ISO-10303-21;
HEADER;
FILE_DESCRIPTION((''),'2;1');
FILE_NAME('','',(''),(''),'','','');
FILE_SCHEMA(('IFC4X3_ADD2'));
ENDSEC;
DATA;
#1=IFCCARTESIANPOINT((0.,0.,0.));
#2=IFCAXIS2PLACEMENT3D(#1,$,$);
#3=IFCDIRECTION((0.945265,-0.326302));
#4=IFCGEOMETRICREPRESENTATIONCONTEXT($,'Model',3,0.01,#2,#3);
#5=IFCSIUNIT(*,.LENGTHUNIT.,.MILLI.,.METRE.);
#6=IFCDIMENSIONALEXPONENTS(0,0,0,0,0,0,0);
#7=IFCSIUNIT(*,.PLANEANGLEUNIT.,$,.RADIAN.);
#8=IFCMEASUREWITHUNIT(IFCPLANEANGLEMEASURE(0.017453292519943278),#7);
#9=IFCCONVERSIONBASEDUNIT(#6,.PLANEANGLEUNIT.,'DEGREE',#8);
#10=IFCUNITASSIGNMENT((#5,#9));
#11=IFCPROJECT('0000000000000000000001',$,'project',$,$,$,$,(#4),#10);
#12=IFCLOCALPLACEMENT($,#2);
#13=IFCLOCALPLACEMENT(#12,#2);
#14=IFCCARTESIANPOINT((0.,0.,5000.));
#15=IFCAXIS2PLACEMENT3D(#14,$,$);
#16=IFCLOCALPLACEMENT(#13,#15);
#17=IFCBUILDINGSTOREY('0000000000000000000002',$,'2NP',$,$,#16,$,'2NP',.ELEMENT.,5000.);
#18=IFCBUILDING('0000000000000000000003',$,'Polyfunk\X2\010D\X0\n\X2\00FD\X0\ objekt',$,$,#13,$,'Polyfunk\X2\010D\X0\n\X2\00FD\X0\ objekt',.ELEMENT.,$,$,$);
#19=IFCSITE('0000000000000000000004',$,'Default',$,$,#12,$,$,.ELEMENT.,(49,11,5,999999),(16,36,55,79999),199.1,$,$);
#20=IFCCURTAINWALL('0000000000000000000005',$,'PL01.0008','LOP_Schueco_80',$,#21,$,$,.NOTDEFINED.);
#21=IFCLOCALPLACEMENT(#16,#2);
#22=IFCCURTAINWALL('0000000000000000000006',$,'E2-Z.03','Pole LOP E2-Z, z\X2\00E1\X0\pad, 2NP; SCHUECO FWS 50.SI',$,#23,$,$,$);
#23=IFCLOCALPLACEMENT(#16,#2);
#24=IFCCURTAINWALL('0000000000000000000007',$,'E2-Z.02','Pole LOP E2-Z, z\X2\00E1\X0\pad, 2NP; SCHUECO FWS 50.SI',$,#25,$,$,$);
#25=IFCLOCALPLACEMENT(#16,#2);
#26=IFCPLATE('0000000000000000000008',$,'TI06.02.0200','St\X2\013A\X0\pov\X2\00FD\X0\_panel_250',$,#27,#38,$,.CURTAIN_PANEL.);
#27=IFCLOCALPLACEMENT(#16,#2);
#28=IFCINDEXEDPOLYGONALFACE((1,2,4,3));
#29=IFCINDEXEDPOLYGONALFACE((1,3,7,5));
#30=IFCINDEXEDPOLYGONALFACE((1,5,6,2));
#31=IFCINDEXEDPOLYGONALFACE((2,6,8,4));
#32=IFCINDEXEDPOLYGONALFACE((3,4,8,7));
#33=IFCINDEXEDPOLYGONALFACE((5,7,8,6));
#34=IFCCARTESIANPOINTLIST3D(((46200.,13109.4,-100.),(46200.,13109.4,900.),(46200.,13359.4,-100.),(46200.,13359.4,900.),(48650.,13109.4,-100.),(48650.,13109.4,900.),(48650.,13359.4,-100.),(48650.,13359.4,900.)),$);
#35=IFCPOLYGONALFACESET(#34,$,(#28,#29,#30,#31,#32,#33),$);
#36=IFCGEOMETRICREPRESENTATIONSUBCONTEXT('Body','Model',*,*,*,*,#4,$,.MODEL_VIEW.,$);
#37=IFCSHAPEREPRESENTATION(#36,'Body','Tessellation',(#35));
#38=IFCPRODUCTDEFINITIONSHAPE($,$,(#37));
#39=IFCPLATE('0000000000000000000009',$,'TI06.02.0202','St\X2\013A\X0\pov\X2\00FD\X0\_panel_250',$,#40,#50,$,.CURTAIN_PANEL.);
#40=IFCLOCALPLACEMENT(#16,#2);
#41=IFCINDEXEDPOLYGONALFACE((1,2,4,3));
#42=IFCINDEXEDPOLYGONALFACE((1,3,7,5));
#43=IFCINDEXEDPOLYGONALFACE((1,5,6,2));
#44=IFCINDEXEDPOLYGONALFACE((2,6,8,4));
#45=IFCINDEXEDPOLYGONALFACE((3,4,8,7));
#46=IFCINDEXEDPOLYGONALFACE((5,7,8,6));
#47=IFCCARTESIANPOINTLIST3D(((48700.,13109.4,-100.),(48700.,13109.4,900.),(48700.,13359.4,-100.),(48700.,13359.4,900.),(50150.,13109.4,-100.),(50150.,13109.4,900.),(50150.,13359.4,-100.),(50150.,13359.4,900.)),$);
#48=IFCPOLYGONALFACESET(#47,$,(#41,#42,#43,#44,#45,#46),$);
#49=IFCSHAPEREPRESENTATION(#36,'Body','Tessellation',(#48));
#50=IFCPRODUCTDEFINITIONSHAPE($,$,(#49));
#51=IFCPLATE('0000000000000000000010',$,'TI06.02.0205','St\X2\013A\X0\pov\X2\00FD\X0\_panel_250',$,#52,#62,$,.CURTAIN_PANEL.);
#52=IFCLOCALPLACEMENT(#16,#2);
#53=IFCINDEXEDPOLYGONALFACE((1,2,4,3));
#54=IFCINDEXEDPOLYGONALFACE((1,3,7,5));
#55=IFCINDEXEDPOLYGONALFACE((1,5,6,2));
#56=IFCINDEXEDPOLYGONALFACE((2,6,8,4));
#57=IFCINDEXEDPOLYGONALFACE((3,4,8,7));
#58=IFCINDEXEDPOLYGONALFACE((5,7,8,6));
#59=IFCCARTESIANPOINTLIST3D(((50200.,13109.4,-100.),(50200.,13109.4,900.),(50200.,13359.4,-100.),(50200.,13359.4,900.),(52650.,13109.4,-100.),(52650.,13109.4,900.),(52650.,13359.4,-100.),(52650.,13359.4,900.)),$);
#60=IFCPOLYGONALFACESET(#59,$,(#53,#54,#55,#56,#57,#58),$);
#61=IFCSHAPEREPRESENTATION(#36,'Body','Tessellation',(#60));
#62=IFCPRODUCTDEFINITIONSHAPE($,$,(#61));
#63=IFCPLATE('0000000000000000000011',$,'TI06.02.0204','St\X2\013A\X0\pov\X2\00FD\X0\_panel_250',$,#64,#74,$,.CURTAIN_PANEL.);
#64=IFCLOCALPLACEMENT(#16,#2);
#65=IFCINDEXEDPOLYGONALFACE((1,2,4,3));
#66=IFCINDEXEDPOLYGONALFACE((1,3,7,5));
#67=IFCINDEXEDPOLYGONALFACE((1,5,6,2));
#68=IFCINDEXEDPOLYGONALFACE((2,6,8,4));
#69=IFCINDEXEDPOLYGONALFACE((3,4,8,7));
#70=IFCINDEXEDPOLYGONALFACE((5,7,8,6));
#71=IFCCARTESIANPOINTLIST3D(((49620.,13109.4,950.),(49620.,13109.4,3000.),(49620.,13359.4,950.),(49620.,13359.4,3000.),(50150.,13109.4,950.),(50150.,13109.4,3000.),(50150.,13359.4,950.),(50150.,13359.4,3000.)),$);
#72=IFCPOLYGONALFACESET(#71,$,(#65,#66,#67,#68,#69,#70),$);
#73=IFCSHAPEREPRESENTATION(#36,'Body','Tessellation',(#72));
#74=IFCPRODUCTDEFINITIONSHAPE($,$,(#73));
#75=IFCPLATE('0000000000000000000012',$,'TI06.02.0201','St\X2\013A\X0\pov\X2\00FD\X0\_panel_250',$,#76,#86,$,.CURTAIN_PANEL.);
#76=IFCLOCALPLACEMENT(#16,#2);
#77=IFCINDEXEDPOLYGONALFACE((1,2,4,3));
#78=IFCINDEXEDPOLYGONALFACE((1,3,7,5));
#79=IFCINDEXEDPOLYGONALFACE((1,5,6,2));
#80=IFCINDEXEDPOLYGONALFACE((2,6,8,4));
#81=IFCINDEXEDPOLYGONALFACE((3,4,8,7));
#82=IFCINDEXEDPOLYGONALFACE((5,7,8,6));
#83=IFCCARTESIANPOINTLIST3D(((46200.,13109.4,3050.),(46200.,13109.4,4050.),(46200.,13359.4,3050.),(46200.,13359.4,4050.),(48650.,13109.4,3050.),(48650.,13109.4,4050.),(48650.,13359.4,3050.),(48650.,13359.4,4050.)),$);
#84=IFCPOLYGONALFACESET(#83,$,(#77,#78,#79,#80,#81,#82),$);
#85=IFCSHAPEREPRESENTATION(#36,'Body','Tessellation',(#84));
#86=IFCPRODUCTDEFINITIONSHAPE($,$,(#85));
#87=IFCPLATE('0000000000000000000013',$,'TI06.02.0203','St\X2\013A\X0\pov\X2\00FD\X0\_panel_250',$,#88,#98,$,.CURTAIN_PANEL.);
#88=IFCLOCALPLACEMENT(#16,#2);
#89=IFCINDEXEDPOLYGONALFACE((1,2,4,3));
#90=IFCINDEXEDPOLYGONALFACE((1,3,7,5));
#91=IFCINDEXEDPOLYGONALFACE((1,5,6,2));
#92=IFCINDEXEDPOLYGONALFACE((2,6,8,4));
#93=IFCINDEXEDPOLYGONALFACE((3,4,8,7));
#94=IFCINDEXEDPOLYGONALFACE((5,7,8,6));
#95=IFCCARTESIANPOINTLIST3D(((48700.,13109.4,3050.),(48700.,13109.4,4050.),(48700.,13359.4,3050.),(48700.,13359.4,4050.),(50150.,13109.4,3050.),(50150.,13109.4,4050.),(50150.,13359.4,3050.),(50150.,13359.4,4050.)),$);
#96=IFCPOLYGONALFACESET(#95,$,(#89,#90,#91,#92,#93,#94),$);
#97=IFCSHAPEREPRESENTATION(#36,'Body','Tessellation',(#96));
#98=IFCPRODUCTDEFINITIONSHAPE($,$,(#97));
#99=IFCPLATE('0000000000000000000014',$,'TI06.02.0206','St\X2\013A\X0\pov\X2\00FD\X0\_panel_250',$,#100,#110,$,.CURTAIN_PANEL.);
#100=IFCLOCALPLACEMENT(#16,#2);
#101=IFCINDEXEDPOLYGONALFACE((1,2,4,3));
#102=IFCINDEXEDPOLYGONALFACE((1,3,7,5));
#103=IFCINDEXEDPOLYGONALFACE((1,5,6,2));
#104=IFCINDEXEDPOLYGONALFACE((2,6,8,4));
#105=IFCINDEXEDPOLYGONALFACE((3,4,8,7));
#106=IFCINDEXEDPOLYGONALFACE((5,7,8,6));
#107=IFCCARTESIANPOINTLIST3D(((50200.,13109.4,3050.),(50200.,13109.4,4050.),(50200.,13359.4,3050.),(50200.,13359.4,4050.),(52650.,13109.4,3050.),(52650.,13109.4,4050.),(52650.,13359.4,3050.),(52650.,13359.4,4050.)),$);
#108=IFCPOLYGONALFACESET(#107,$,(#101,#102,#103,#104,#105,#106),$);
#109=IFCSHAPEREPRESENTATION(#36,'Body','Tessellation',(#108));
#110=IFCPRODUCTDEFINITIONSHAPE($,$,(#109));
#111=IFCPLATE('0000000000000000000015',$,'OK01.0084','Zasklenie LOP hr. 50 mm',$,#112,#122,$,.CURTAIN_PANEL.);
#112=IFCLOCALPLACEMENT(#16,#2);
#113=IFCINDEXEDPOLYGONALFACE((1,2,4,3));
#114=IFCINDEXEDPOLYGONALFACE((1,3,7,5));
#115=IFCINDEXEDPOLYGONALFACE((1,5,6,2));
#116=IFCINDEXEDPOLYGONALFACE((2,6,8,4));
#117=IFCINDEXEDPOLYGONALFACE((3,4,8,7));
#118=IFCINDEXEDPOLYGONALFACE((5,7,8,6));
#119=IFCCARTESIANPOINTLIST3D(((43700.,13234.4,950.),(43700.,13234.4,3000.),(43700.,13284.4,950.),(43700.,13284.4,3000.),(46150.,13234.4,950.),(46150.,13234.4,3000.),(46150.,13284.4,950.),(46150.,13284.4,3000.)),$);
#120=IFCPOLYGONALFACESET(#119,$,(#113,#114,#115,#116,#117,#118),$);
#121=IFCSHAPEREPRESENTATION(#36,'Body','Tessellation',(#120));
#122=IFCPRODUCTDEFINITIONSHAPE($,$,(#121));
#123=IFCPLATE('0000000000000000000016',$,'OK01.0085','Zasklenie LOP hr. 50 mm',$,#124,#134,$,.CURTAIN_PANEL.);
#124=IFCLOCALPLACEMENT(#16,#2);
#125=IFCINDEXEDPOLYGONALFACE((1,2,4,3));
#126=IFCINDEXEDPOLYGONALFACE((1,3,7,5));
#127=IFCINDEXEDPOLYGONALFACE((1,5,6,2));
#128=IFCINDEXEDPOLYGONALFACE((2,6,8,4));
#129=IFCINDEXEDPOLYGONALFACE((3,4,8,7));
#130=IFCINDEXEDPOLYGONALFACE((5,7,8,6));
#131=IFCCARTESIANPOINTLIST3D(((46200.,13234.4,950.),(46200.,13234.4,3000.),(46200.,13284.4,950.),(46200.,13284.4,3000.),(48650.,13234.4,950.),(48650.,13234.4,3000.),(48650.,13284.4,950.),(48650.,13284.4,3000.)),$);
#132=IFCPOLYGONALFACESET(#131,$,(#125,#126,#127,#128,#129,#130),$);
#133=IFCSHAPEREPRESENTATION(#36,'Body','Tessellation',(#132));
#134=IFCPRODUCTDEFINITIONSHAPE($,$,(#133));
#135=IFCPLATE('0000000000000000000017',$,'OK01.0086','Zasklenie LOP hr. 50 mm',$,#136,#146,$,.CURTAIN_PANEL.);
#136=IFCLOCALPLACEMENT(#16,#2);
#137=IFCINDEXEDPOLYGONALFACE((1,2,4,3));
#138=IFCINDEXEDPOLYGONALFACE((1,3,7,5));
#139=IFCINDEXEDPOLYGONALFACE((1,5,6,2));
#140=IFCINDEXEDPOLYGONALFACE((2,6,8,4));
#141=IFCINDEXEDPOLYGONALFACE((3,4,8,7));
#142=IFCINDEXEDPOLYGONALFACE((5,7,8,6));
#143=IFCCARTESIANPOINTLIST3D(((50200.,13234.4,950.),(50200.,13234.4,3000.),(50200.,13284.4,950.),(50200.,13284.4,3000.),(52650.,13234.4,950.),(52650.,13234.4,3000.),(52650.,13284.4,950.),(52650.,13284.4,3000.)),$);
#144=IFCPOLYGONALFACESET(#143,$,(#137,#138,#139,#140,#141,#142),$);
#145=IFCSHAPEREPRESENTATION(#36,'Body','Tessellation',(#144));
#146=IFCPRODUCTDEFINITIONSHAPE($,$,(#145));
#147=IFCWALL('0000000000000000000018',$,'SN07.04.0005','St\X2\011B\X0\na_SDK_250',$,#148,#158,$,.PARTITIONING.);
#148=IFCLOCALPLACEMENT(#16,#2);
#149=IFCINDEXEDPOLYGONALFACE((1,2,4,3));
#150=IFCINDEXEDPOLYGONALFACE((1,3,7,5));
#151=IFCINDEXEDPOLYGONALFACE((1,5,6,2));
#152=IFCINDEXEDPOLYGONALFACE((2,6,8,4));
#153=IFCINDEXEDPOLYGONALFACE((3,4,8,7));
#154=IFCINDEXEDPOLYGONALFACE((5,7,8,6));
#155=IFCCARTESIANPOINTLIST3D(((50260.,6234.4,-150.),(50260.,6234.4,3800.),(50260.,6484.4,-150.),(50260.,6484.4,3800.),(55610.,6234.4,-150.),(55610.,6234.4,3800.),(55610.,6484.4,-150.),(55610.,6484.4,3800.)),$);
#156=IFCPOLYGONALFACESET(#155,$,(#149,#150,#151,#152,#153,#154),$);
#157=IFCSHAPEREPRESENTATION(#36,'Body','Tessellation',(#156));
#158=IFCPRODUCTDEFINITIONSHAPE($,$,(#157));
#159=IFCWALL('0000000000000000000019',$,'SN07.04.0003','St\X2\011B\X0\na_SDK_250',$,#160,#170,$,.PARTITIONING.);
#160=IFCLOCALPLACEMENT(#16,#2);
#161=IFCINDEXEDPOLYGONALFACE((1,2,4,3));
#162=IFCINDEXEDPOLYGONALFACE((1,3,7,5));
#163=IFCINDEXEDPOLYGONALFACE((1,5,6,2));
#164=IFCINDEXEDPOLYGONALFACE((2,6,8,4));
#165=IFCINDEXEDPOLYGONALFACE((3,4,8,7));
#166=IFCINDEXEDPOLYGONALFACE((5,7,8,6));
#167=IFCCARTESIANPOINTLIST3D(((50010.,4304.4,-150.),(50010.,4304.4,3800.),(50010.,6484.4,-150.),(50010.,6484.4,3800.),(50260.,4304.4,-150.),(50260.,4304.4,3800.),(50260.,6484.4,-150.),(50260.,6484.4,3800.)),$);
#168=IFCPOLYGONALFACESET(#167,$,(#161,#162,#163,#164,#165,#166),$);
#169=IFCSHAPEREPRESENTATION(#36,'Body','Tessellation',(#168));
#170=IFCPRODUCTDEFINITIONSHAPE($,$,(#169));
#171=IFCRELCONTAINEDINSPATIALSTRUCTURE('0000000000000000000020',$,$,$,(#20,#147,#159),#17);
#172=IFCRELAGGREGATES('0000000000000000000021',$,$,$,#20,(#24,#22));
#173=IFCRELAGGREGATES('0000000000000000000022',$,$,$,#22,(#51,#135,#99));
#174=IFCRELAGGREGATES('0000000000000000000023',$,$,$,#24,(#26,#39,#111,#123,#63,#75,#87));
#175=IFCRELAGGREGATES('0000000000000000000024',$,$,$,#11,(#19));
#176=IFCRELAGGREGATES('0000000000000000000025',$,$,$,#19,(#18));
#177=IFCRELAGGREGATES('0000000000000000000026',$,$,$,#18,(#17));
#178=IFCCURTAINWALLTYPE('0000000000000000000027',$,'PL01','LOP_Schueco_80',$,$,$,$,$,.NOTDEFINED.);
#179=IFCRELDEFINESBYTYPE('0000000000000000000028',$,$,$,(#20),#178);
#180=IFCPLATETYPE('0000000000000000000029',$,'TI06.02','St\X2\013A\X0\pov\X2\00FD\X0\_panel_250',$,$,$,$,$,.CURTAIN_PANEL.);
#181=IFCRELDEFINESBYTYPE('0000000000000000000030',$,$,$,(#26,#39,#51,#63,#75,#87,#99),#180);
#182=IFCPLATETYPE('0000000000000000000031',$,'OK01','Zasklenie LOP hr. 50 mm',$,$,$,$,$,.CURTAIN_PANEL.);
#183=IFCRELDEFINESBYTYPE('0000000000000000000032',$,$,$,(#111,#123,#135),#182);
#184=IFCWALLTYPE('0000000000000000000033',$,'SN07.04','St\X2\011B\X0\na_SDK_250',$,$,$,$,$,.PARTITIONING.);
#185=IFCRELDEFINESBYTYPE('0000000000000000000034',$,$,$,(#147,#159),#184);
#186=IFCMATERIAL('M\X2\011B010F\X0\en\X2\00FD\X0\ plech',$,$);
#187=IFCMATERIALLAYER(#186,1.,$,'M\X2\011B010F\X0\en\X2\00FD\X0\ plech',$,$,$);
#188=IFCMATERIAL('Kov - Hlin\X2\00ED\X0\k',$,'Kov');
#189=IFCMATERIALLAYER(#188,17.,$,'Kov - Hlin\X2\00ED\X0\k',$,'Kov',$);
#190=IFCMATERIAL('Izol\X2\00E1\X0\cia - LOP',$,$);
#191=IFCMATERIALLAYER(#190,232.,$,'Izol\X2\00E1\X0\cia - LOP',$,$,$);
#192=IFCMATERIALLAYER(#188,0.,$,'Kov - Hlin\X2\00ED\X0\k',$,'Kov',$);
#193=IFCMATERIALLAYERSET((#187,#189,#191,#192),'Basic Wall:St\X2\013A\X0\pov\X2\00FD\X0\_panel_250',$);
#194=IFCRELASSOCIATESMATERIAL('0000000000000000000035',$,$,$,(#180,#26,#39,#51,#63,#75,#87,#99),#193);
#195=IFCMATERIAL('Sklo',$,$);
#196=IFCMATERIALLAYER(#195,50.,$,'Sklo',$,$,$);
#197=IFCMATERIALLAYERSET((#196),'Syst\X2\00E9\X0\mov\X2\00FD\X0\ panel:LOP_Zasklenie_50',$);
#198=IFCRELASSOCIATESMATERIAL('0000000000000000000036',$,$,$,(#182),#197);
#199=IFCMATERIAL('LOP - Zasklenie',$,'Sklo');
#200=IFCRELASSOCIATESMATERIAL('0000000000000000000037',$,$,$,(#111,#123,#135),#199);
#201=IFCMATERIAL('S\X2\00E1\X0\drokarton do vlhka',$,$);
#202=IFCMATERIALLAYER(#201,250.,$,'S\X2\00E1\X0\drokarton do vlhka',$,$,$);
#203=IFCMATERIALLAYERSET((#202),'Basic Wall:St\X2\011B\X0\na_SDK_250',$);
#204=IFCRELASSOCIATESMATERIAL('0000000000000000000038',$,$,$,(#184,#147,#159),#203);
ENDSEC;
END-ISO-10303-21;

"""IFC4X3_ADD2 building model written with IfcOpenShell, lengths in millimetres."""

from ifc_helpers import new_model, entity, si_unit, converted_unit, direction, frame, frame_2d, origin, origin_2d_with_axis, place, context, subcontext, project, spatial, polyline, rectangle, extrude, clip, bounded_halfspace, source, transform, mapped, material, layer, layer_set, layer_usage, type_object, type_shapes, element, aggregate, save


model = new_model("IFC4X3_ADD2")

# Units and contexts
model_context = context("Model", 3, precision=0.01, world=origin(), true_north=direction((0.945265, -0.326302)))
body_context = subcontext(model_context, "Body", "Model", "MODEL_VIEW")
ifc_project = project(units=[si_unit("LENGTHUNIT", "METRE", prefix="MILLI"), converted_unit("PLANEANGLEUNIT", "DEGREE", entity("IfcPlaneAngleMeasure", 0.017453292519943278), si_unit("PLANEANGLEUNIT", "RADIAN"), dimensions=[0, 0, 0, 0, 0, 0, 0])], contexts=[model_context])

# Site, building, storey
site_placement = place(None, origin())
site = spatial("IfcSite", under=ifc_project, at=site_placement, Name="Default", CompositionType="ELEMENT", RefLatitude=(49, 11, 5, 999999), RefLongitude=(16, 36, 55, 79999), RefElevation=199.1)
building_placement = place(site_placement, origin())
building = spatial("IfcBuilding", under=site, at=building_placement, Name="Polyfunkčný objekt", LongName="Polyfunkčný objekt", CompositionType="ELEMENT")
storey_placement = place(building_placement, frame((0.0, 0.0, 5000.0)))
storey = spatial("IfcBuildingStorey", under=building, at=storey_placement, Name="2NP", LongName="2NP", CompositionType="ELEMENT", Elevation=5000.0)

# Curtain walls, plates
curtain_wall_type = type_object("IfcCurtainWallType", Name="PL01", Description="LOP_Schueco_80", PredefinedType="NOTDEFINED")
curtain_wall_1_placement = place(storey_placement, frame((0.0, 0.0, -5000.0)))
curtain_wall_1 = element("IfcCurtainWall", 1, at=curtain_wall_1_placement, inside=storey, type_object=curtain_wall_type, Name="PL01.0008", Description="LOP_Schueco_80", PredefinedType="NOTDEFINED")
curtain_wall_2 = element("IfcCurtainWall", 2, Name="E2-Z.03", Description="Pole LOP E2-Z, západ, 2NP; SCHUECO FWS 50.SI")
curtain_wall_3 = element("IfcCurtainWall", 3, Name="E2-Z.02", Description="Pole LOP E2-Z, západ, 2NP; SCHUECO FWS 50.SI")
aggregate(curtain_wall_1, [curtain_wall_3, curtain_wall_2])
ifc_material_1 = material(Name="Měďený plech")
ifc_layer_1 = layer(ifc_material_1, 1.0, Name="Měďený plech")
ifc_material_2 = material(Name="Kov - Hliník", Category="Kov")
ifc_layer_2 = layer(ifc_material_2, 17.0, Name="Kov - Hliník", Category="Kov")
ifc_material_3 = material(Name="Izolácia - LOP")
ifc_layer_3 = layer(ifc_material_3, 232.0, Name="Izolácia - LOP")
ifc_layer_4 = layer(ifc_material_2, 0.0, Name="Kov - Hliník", Category="Kov")
ifc_layer_set_1 = layer_set([ifc_layer_1, ifc_layer_2, ifc_layer_3, ifc_layer_4], Name="Basic Wall:Stĺpový_panel_250")
ifc_layer_usage_1 = layer_usage(ifc_layer_set_1, "AXIS2", "NEGATIVE", 125.0)
plate_type_1 = type_object("IfcPlateType", Name="TI06.02", Description="Stĺpový_panel_250", PredefinedType="CURTAIN_PANEL", material=ifc_layer_set_1)
plate_1_placement = place(storey_placement, frame((46200.0, 13234.4, -100.0)))
plate_1 = element("IfcPlate", 4, at=plate_1_placement, type_object=plate_type_1, material=ifc_layer_usage_1, Name="TI06.02.0200", Description="Stĺpový_panel_250", PredefinedType="CURTAIN_PANEL", context=body_context, shape_type="SweptSolid", body=[
    extrude(rectangle(XDim=250.0, YDim=2450.0, at=frame_2d((0.0, 0.0), x_axis=(1.0, 0.0))), frame((1225.0, 0.0, 0.0), z_axis=(0.0, 0.0, 1.0), x_axis=(0.0, 1.0, 0.0)), (0.0, 0.0, 1.0), 1000.0),
])
ifc_layer_usage_2 = layer_usage(ifc_layer_set_1, "AXIS2", "NEGATIVE", 125.0)
plate_2_placement = place(storey_placement, frame((48700.0, 13234.4, -100.0)))
plate_2 = element("IfcPlate", 5, at=plate_2_placement, type_object=plate_type_1, material=ifc_layer_usage_2, Name="TI06.02.0202", Description="Stĺpový_panel_250", PredefinedType="CURTAIN_PANEL", context=body_context, shape_type="SweptSolid", body=[
    extrude(rectangle(XDim=250.0, YDim=1450.0, at=frame_2d((0.0, 0.0), x_axis=(1.0, 0.0))), frame((725.0, 0.0, 0.0), z_axis=(0.0, 0.0, 1.0), x_axis=(0.0, 1.0, 0.0)), (0.0, 0.0, 1.0), 1000.0),
])
ifc_layer_usage_3 = layer_usage(ifc_layer_set_1, "AXIS2", "NEGATIVE", 125.0)
plate_3_placement = place(storey_placement, frame((50200.0, 13234.4, -100.0)))
plate_3 = element("IfcPlate", 6, at=plate_3_placement, type_object=plate_type_1, material=ifc_layer_usage_3, Name="TI06.02.0205", Description="Stĺpový_panel_250", PredefinedType="CURTAIN_PANEL", context=body_context, shape_type="SweptSolid", body=[
    extrude(rectangle(XDim=250.0, YDim=2450.0, at=origin_2d_with_axis()), frame((1225.0, 0.0, 0.0), z_axis=(0.0, 0.0, 1.0), x_axis=(0.0, 1.0, 0.0)), (0.0, 0.0, 1.0), 1000.0),
])
ifc_layer_usage_4 = layer_usage(ifc_layer_set_1, "AXIS2", "NEGATIVE", 125.0)
plate_4_placement = place(storey_placement, frame((49620.0, 13234.4, 950.0)))
plate_4 = element("IfcPlate", 7, at=plate_4_placement, type_object=plate_type_1, material=ifc_layer_usage_4, Name="TI06.02.0204", Description="Stĺpový_panel_250", PredefinedType="CURTAIN_PANEL", context=body_context, shape_type="SweptSolid", body=[
    extrude(rectangle(XDim=250.0, YDim=530.0, at=frame_2d((0.0, 0.0), x_axis=(1.0, 0.0))), frame((265.0, 0.0, 0.0), z_axis=(0.0, 0.0, 1.0), x_axis=(0.0, 1.0, 0.0)), (0.0, 0.0, 1.0), 2050.0),
])
ifc_layer_usage_5 = layer_usage(ifc_layer_set_1, "AXIS2", "NEGATIVE", 125.0)
plate_5_placement = place(storey_placement, frame((46200.0, 13234.4, 3050.0)))
plate_5 = element("IfcPlate", 8, at=plate_5_placement, type_object=plate_type_1, material=ifc_layer_usage_5, Name="TI06.02.0201", Description="Stĺpový_panel_250", PredefinedType="CURTAIN_PANEL", context=body_context, shape_type="SweptSolid", body=[
    extrude(rectangle(XDim=250.0, YDim=2450.0, at=frame_2d((0.0, 0.0), x_axis=(1.0, 0.0))), frame((1225.0, 0.0, 0.0), z_axis=(0.0, 0.0, 1.0), x_axis=(0.0, 1.0, 0.0)), (0.0, 0.0, 1.0), 1000.0),
])
ifc_layer_usage_6 = layer_usage(ifc_layer_set_1, "AXIS2", "NEGATIVE", 125.0)
plate_6_placement = place(storey_placement, frame((48700.0, 13234.4, 3050.0)))
plate_6 = element("IfcPlate", 9, at=plate_6_placement, type_object=plate_type_1, material=ifc_layer_usage_6, Name="TI06.02.0203", Description="Stĺpový_panel_250", PredefinedType="CURTAIN_PANEL", context=body_context, shape_type="SweptSolid", body=[
    extrude(rectangle(XDim=250.0, YDim=1450.0, at=frame_2d((0.0, 0.0), x_axis=(1.0, 0.0))), frame((725.0, 0.0, 0.0), z_axis=(0.0, 0.0, 1.0), x_axis=(0.0, 1.0, 0.0)), (0.0, 0.0, 1.0), 1000.0),
])
ifc_layer_usage_7 = layer_usage(ifc_layer_set_1, "AXIS2", "NEGATIVE", 125.0)
plate_7_placement = place(storey_placement, frame((50200.0, 13234.4, 3050.0)))
plate_7 = element("IfcPlate", 10, at=plate_7_placement, type_object=plate_type_1, material=ifc_layer_usage_7, Name="TI06.02.0206", Description="Stĺpový_panel_250", PredefinedType="CURTAIN_PANEL", context=body_context, shape_type="SweptSolid", body=[
    extrude(rectangle(XDim=250.0, YDim=2450.0, at=origin_2d_with_axis()), frame((1225.0, 0.0, 0.0), z_axis=(0.0, 0.0, 1.0), x_axis=(0.0, 1.0, 0.0)), (0.0, 0.0, 1.0), 1000.0),
])
ifc_material_4 = material(Name="LOP - Zasklenie", Category="Sklo")
ifc_material_5 = material(Name="Sklo")
ifc_layer_5 = layer(ifc_material_5, 50.0, Name="Sklo")
ifc_layer_set_2 = layer_set([ifc_layer_5], Name="Systémový panel:LOP_Zasklenie_50")
plate_type_2 = type_object("IfcPlateType", Name="OK01", Description="Zasklenie LOP hr. 50 mm", PredefinedType="CURTAIN_PANEL", material=ifc_layer_set_2)
shared_shape_1 = source(origin(), body_context, "Body", "SweptSolid", [
    extrude(rectangle(XDim=50.0, YDim=2450.0, at=origin_2d_with_axis()), frame((0.0, 25.0, 0.0), z_axis=(0.0, 0.0, 1.0), x_axis=(0.0, 1.0, 0.0)), (0.0, 0.0, 1.0), 2050.0),
])
type_shapes(plate_type_2, [shared_shape_1])
plate_8_placement = place(curtain_wall_1_placement, frame((44925.0, 13234.4, 5950.0)))
plate_8 = element("IfcPlate", 11, at=plate_8_placement, type_object=plate_type_2, material=ifc_material_4, Name="OK01.0084", Description="Zasklenie LOP hr. 50 mm", PredefinedType="CURTAIN_PANEL", context=body_context, shape_type="MappedRepresentation", body=[
    mapped(shared_shape_1, transform((0.0, 0.0, 0.0), scale=1.0)),
])
plate_9_placement = place(curtain_wall_1_placement, frame((47425.0, 13234.4, 5950.0)))
plate_9 = element("IfcPlate", 12, at=plate_9_placement, type_object=plate_type_2, material=ifc_material_4, Name="OK01.0085", Description="Zasklenie LOP hr. 50 mm", PredefinedType="CURTAIN_PANEL", context=body_context, shape_type="MappedRepresentation", body=[
    mapped(shared_shape_1, transform((0.0, 0.0, 0.0), scale=1.0)),
])
plate_10_placement = place(curtain_wall_1_placement, frame((51425.0, 13234.4, 5950.0)))
plate_10 = element("IfcPlate", 13, at=plate_10_placement, type_object=plate_type_2, material=ifc_material_4, Name="OK01.0086", Description="Zasklenie LOP hr. 50 mm", PredefinedType="CURTAIN_PANEL", context=body_context, shape_type="MappedRepresentation", body=[
    mapped(shared_shape_1, transform((0.0, 0.0, 0.0), scale=1.0)),
])
aggregate(curtain_wall_2, [plate_3, plate_10, plate_7])

# Walls
ifc_material_6 = material(Name="Sádrokarton do vlhka")
ifc_layer_6 = layer(ifc_material_6, 250.0, Name="Sádrokarton do vlhka")
ifc_layer_set_3 = layer_set([ifc_layer_6], Name="Basic Wall:Stěna_SDK_250")
wall_type_1 = type_object("IfcWallType", Name="SN07.04", Description="Stěna_SDK_250", PredefinedType="PARTITIONING", material=ifc_layer_set_3)
wall_1_placement = place(storey_placement, frame((50260.0, 6359.4, -150.0)))
element("IfcWall", 14, at=wall_1_placement, inside=storey, type_object=wall_type_1, material=ifc_layer_set_3, Name="SN07.04.0005", Description="Stěna_SDK_250", PredefinedType="PARTITIONING", context=body_context, shape_type="Clipping", body=[
    clip(clip(extrude(rectangle(XDim=5350.0, YDim=250.0, at=frame_2d((2675.0, 0.0), x_axis=(-1.0, 0.0))), origin(), (0.0, 0.0, 1.0), 3950.0), bounded_halfspace(frame((5350.0, -125.0, 0.0), z_axis=(0.0, 0.0, 1.0), x_axis=(-1.0, 0.0, 0.0)), True, frame((5350.0, -125.0, 0.0)), polyline([(0.0, 0.0), (0.0, 250.0), (-5350.0, 250.0), (-5350.0, 0.0), (-1670.0, 0.0), (-1520.0, 0.0), (0.0, 0.0)]))), bounded_halfspace(frame((0.0, -125.0, 3950.0), z_axis=(0.0, 0.0, -1.0), x_axis=(1.0, 0.0, 0.0)), True, frame((0.0, -125.0, 3950.0)), polyline([(0.0, 0.0), (3680.0, 0.0), (3830.0, 0.0), (5350.0, 0.0), (5350.0, 250.0), (0.0, 250.0), (0.0, 0.0)]))),
])
wall_2_placement = place(storey_placement, frame((50135.0, 6484.4, -150.0), z_axis=(0.0, 0.0, 1.0), x_axis=(0.0, -1.0, 0.0)))
element("IfcWall", 15, at=wall_2_placement, inside=storey, type_object=wall_type_1, material=ifc_layer_set_3, Name="SN07.04.0003", Description="Stěna_SDK_250", PredefinedType="PARTITIONING", context=body_context, shape_type="Clipping", body=[
    clip(clip(extrude(rectangle(XDim=2180.0, YDim=250.0, at=frame_2d((1090.0, 0.0), x_axis=(-1.0, 0.0))), origin(), (0.0, 0.0, 1.0), 3950.0), bounded_halfspace(frame((2180.0, -125.0, 0.0), z_axis=(0.0, 0.0, 1.0), x_axis=(0.0, -1.0, 0.0)), True, frame((2180.0, -125.0, 0.0)), polyline([(0.0, 0.0), (0.0, 250.0), (-1930.0, 250.0), (-2180.0, 250.0), (-2180.0, 0.0), (0.0, 0.0)]))), bounded_halfspace(frame((0.0, -125.0, 3950.0), z_axis=(0.0, 0.0, -1.0), x_axis=(0.0, 1.0, 0.0)), True, frame((0.0, -125.0, 3950.0)), polyline([(0.0, 0.0), (2180.0, 0.0), (2180.0, 250.0), (250.0, 250.0), (0.0, 250.0), (0.0, 0.0)]))),
])

aggregate(curtain_wall_3, [plate_1, plate_2, plate_8, plate_9, plate_4, plate_5, plate_6])

save(model, "model.ifc")
